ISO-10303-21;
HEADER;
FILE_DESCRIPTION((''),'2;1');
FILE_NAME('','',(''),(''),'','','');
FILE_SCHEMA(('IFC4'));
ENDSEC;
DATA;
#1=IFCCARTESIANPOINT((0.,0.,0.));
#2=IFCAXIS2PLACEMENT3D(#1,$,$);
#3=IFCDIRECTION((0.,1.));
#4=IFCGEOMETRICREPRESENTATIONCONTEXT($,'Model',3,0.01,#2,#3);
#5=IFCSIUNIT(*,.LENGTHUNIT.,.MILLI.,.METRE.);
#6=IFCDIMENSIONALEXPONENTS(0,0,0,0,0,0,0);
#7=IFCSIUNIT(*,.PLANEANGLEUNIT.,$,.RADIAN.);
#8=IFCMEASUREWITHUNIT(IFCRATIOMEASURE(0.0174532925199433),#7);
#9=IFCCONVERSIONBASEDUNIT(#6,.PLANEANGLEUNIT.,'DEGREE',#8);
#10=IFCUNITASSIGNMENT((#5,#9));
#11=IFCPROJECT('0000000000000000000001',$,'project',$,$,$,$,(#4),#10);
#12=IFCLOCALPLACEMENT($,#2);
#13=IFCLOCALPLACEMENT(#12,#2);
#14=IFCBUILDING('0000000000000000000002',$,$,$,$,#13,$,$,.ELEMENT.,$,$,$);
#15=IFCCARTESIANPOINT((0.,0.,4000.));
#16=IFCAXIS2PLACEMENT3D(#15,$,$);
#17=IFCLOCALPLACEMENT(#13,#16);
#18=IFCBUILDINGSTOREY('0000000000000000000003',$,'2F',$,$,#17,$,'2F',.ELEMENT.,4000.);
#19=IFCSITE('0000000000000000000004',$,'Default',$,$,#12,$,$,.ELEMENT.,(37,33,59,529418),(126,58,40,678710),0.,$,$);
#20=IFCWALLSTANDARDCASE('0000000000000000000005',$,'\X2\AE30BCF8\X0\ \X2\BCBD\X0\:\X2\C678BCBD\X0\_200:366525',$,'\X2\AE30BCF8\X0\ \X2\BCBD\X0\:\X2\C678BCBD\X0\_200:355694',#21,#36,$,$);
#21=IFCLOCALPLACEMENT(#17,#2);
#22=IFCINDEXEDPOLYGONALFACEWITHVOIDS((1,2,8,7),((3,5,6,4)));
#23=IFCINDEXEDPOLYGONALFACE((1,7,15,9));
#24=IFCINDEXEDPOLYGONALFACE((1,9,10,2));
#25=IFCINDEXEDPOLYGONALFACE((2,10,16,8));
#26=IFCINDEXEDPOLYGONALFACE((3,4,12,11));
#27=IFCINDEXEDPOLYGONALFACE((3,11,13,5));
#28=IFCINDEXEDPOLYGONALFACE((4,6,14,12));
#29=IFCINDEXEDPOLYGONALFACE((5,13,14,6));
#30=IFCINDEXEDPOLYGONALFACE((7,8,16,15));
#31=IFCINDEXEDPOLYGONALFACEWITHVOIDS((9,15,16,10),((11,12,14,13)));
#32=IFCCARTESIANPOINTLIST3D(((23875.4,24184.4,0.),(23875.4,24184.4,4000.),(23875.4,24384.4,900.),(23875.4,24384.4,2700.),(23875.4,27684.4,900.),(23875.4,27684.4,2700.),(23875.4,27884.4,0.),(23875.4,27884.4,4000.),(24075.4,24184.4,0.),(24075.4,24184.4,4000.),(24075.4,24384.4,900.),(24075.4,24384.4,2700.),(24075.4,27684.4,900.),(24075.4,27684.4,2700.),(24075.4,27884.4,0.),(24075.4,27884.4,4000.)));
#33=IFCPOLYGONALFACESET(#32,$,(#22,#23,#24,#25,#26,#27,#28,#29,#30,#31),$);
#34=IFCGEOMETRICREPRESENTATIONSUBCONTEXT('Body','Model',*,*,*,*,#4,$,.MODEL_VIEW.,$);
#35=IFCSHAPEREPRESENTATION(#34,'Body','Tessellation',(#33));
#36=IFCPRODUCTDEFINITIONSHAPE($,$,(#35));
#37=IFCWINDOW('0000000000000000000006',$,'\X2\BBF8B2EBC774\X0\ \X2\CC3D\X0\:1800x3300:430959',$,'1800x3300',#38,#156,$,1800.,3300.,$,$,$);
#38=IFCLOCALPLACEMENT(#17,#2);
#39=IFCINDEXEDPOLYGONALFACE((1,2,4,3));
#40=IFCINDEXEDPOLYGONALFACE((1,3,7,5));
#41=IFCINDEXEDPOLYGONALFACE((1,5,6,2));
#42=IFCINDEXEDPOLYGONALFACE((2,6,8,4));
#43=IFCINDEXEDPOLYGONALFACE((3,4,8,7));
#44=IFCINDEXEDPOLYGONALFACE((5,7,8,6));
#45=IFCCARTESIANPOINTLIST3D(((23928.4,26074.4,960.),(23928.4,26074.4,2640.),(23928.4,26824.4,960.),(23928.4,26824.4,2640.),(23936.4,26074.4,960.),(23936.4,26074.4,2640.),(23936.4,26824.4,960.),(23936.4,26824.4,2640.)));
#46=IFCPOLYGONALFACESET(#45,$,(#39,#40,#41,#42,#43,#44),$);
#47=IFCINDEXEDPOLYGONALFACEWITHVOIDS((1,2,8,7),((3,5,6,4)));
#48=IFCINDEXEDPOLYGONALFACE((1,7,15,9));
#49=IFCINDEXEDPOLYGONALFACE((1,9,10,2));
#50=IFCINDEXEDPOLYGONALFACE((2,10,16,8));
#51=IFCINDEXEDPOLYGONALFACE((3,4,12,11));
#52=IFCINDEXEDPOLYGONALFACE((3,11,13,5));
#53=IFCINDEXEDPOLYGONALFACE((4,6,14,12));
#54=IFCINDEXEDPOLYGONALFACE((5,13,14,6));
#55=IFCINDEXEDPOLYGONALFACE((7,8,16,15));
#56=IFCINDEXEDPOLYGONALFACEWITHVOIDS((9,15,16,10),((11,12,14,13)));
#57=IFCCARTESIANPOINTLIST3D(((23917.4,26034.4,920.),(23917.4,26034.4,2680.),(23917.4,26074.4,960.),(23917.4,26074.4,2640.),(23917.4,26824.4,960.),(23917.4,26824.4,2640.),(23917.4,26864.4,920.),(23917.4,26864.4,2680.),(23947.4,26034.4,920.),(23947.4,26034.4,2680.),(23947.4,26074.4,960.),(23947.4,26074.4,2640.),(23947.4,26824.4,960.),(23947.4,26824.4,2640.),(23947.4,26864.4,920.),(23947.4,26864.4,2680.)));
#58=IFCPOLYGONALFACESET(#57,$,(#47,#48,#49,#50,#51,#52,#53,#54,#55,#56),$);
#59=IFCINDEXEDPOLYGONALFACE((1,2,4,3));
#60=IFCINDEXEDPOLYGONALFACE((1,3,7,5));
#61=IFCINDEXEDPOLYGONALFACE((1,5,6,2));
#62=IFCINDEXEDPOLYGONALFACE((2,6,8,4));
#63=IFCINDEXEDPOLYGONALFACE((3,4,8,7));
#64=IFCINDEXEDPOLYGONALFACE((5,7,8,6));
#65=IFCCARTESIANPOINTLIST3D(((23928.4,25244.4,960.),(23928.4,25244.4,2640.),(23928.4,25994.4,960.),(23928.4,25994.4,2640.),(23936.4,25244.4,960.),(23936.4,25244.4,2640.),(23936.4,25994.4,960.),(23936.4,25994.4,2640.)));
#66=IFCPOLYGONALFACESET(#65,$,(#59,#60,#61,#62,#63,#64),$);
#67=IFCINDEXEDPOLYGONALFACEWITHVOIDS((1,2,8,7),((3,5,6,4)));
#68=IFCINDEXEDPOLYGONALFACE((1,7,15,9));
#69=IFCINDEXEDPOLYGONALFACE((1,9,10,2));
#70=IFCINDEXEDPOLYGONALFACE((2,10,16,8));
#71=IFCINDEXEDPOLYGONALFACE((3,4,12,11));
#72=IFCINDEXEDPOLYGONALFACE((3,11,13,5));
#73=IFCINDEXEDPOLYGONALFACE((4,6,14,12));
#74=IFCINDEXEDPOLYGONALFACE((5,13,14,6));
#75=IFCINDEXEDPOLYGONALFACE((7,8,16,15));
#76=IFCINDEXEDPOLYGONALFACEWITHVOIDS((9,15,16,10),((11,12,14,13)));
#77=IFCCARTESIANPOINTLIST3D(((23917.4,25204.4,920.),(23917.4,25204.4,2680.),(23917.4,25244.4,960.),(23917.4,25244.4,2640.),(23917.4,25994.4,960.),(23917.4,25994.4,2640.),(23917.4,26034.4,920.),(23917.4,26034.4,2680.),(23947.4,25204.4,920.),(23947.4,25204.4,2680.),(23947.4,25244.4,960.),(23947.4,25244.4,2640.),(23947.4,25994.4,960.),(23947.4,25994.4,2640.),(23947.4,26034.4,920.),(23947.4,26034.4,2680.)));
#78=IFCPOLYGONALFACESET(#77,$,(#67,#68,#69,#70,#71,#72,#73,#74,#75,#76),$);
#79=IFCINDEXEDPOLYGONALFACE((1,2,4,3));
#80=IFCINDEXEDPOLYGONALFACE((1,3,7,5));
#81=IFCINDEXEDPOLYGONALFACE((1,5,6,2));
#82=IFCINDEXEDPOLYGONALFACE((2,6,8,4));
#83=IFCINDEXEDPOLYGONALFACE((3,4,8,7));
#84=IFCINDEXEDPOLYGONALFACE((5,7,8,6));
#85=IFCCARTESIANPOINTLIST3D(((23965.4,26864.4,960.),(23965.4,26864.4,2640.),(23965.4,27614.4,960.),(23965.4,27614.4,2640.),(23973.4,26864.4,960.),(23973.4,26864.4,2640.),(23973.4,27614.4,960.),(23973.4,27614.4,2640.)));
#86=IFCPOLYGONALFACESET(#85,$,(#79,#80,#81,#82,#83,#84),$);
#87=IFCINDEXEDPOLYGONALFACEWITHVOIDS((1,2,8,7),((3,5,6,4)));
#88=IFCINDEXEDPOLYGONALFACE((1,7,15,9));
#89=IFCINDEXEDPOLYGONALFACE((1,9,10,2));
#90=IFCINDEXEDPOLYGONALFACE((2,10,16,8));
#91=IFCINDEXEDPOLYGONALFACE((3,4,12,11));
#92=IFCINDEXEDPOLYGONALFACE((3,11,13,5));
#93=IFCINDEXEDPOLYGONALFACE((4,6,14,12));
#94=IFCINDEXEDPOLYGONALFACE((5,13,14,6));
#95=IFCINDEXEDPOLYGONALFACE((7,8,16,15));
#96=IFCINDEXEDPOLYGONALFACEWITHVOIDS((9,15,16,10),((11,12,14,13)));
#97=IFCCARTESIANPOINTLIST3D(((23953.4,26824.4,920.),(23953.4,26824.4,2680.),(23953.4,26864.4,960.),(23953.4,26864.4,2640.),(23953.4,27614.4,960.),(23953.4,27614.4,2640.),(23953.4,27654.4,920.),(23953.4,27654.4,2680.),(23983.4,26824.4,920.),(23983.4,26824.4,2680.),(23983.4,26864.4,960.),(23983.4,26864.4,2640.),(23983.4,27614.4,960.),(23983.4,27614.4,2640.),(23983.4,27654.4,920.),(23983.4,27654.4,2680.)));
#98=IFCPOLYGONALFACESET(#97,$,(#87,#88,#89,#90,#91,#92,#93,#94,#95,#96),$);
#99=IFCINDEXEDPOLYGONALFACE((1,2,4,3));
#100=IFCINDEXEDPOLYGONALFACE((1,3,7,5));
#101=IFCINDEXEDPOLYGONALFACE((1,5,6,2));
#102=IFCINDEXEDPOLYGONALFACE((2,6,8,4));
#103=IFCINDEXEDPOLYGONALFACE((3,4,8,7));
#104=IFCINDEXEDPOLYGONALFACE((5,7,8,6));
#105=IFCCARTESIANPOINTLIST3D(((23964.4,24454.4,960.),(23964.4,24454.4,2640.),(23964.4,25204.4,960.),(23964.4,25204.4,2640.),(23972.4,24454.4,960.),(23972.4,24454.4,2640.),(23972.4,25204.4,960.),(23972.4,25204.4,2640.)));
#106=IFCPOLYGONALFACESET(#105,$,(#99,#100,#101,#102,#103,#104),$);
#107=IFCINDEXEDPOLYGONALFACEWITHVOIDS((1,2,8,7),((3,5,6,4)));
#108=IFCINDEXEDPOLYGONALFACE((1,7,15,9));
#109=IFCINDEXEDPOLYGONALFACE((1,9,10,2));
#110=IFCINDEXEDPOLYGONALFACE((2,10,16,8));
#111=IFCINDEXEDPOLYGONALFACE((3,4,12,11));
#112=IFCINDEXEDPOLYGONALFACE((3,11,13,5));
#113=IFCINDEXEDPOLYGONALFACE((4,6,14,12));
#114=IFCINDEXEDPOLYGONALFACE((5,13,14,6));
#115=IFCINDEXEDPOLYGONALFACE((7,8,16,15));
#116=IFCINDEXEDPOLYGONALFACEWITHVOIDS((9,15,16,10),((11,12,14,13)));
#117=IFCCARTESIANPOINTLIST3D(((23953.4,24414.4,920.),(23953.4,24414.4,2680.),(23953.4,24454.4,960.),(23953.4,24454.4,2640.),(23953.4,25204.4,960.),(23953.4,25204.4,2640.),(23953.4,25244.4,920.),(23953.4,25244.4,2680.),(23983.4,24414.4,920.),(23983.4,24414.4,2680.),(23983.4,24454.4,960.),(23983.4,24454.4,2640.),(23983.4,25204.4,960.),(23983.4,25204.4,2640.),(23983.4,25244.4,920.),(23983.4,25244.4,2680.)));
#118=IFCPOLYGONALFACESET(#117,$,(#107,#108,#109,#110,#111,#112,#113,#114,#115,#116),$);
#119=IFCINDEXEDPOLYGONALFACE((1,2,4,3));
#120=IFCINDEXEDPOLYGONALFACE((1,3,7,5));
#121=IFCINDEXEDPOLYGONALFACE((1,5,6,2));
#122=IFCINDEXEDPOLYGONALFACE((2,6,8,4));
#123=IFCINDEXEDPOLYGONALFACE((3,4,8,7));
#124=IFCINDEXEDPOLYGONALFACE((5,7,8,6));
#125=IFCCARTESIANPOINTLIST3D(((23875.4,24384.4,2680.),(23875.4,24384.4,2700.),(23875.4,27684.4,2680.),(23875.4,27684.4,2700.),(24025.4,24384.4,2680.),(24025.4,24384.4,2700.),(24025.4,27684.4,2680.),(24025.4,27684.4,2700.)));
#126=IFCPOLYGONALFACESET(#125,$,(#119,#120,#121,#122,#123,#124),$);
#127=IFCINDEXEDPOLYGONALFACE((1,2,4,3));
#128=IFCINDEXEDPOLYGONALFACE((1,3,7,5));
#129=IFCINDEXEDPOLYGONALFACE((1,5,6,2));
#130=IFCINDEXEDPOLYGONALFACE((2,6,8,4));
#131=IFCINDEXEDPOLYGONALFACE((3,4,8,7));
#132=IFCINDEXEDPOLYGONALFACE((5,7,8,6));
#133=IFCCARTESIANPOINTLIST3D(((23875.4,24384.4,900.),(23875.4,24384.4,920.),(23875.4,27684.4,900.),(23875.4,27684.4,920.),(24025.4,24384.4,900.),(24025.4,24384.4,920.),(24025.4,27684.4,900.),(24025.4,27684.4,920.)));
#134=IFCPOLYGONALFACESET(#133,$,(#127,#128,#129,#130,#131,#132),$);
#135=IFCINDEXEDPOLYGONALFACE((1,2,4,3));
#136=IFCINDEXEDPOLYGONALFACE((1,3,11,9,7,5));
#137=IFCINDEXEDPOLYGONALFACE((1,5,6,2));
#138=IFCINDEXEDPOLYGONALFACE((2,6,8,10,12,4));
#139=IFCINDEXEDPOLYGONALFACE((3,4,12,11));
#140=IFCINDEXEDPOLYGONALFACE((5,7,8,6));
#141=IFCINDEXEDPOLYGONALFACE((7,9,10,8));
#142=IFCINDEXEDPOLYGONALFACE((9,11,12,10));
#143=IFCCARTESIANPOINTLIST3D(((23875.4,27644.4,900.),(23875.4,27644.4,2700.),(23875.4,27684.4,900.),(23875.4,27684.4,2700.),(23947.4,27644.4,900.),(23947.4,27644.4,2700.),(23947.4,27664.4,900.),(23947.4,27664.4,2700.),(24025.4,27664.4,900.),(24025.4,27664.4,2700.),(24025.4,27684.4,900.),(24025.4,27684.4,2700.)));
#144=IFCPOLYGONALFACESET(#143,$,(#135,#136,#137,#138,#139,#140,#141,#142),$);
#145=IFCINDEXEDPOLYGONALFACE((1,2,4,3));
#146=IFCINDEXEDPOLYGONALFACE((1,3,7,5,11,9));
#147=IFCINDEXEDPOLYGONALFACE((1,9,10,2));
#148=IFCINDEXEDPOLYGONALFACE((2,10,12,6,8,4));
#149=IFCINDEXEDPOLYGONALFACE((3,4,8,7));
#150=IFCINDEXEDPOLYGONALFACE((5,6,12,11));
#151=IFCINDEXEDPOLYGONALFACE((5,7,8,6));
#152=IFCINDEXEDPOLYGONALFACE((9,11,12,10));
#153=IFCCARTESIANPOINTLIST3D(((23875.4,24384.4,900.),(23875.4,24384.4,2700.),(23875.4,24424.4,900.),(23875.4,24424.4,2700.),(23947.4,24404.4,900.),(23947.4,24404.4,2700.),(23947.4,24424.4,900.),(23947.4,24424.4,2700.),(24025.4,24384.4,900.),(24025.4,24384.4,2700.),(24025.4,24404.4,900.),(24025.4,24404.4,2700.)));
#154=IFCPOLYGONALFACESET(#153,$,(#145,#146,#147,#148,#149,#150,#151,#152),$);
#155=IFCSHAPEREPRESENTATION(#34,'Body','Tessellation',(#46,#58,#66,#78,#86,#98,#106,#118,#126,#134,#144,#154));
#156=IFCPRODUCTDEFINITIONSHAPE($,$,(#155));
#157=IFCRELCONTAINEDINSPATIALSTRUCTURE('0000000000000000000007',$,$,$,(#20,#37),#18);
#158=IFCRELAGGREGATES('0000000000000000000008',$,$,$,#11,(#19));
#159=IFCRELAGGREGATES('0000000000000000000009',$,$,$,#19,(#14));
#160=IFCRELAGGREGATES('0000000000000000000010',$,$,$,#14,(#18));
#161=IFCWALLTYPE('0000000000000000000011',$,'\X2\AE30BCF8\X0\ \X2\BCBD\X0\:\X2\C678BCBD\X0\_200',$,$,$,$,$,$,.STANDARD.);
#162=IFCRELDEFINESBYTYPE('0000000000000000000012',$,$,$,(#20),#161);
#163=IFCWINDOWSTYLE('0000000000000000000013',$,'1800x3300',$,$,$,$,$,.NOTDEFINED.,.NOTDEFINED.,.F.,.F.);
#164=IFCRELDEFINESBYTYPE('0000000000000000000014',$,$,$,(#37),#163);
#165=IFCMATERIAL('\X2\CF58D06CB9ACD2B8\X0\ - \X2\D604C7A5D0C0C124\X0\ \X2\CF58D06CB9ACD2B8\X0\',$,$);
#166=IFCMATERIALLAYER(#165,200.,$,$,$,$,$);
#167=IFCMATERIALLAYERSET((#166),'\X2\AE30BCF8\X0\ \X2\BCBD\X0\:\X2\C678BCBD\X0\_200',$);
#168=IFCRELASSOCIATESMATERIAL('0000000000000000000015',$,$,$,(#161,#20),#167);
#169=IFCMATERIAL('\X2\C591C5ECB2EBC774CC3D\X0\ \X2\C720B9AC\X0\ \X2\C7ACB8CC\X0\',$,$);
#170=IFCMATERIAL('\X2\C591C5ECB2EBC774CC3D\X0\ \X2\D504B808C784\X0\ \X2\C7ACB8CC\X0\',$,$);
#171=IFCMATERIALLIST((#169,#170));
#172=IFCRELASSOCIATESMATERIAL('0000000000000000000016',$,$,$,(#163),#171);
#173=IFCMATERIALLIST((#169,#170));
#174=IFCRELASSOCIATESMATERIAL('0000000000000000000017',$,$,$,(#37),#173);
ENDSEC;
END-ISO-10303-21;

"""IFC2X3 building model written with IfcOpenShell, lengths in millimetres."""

from ifc_helpers import new_model, entity, si_unit, converted_unit, direction, frame, frame_2d, origin, origin_2d_with_axis, place, context, subcontext, project, spatial, polyline, rectangle, outline, extrude, source, transform, mapped, material, material_list, layer, layer_set, layer_usage, type_object, type_shapes, element, fill, save


model = new_model("IFC2X3")

# Units and contexts
model_context = context("Model", 3, precision=0.01, world=origin(), true_north=direction((0.0, 1.0)))
body_context = subcontext(model_context, "Body", "Model", "MODEL_VIEW")
ifc_project = project(units=[si_unit("LENGTHUNIT", "METRE", prefix="MILLI"), converted_unit("PLANEANGLEUNIT", "DEGREE", entity("IfcRatioMeasure", 0.0174532925199433), si_unit("PLANEANGLEUNIT", "RADIAN"), dimensions=[0, 0, 0, 0, 0, 0, 0])], contexts=[model_context])

# Site, building, storey
site_placement = place(None, origin())
site = spatial("IfcSite", under=ifc_project, at=site_placement, Name="Default", CompositionType="ELEMENT", RefLatitude=(37, 33, 59, 529418), RefLongitude=(126, 58, 40, 678710), RefElevation=0.0)
building_placement = place(site_placement, origin())
building = spatial("IfcBuilding", under=site, at=building_placement, CompositionType="ELEMENT")
storey_placement = place(building_placement, frame((0.0, 0.0, 4000.0)))
storey = spatial("IfcBuildingStorey", under=building, at=storey_placement, Name="2F", LongName="2F", CompositionType="ELEMENT", Elevation=4000.0)

# Shared definitions
ifc_material_1 = material(Name="콘크리트 - 현장타설 콘크리트")

# Wall, opening, window
ifc_layer_1 = layer(ifc_material_1, 200.0)
ifc_layer_set_1 = layer_set([ifc_layer_1], Name="기본 벽:외벽_200")
wall_type_1 = type_object("IfcWallType", Name="기본 벽:외벽_200", PredefinedType="STANDARD", material=ifc_layer_set_1)
ifc_material_2 = material(Name="양여닫이창 유리 재료")
ifc_material_3 = material(Name="양여닫이창 프레임 재료")
ifc_material_list_1 = material_list([ifc_material_2, ifc_material_3])
window_style_1 = type_object("IfcWindowStyle", Name="1800x3300", ConstructionType="NOTDEFINED", OperationType="NOTDEFINED", ParameterTakesPrecedence=False, Sizeable=False, material=ifc_material_list_1)
shared_shape_1 = source(origin(), body_context, "Body", "SweptSolid", [
    extrude(rectangle(XDim=8.0, YDim=750.0, at=frame_2d((0.0, 0.0), x_axis=(1.0, 0.0))), frame((2065.0, 143.0, 60.0), z_axis=(0.0, 0.0, 1.0), x_axis=(0.0, 1.0, 0.0)), (0.0, 0.0, 1.0), 1680.0),
    extrude(outline(polyline([(-880.0, -415.0), (880.0, -415.0), (880.0, 415.0), (-880.0, 415.0), (-880.0, -415.0)]), holes=[polyline([(840.0, -375.0), (-840.0, -375.0), (-840.0, 375.0), (840.0, 375.0), (840.0, -375.0)])]), frame((2065.0, 128.0, 900.0), z_axis=(0.0, 1.0, 0.0), x_axis=(0.0, 0.0, -1.0)), (0.0, 0.0, 1.0), 30.0),
    extrude(rectangle(XDim=8.0, YDim=750.0, at=frame_2d((0.0, 0.0), x_axis=(1.0, 0.0))), frame((1235.0, 143.0, 60.0), z_axis=(0.0, 0.0, 1.0), x_axis=(0.0, 1.0, 0.0)), (0.0, 0.0, 1.0), 1680.0),
    extrude(outline(polyline([(-880.0, -415.0), (880.0, -415.0), (880.0, 415.0), (-880.0, 415.0), (-880.0, -415.0)]), holes=[polyline([(840.0, -375.0), (-840.0, -375.0), (-840.0, 375.0), (840.0, 375.0), (840.0, -375.0)])]), frame((1235.0, 128.0, 900.0), z_axis=(0.0, 1.0, 0.0), x_axis=(0.0, 0.0, -1.0)), (0.0, 0.0, 1.0), 30.0),
    extrude(rectangle(XDim=8.0, YDim=750.0, at=frame_2d((0.0, 0.0), x_axis=(1.0, 0.0))), frame((2855.0, 106.0, 60.0), z_axis=(0.0, 0.0, 1.0), x_axis=(0.0, 1.0, 0.0)), (0.0, 0.0, 1.0), 1680.0),
    extrude(outline(polyline([(-880.0, -415.0), (880.0, -415.0), (880.0, 415.0), (-880.0, 415.0), (-880.0, -415.0)]), holes=[polyline([(840.0, -375.0), (-840.0, -375.0), (-840.0, 375.0), (840.0, 375.0), (840.0, -375.0)])]), frame((2855.0, 92.0, 900.0), z_axis=(0.0, 1.0, 0.0), x_axis=(0.0, 0.0, -1.0)), (0.0, 0.0, 1.0), 30.0),
    extrude(rectangle(XDim=8.0, YDim=750.0, at=origin_2d_with_axis()), frame((445.0, 107.0, 60.0), z_axis=(0.0, 0.0, 1.0), x_axis=(0.0, 1.0, 0.0)), (0.0, 0.0, 1.0), 1680.0),
    extrude(outline(polyline([(-880.0, -415.0), (880.0, -415.0), (880.0, 415.0), (-880.0, 415.0), (-880.0, -415.0)]), holes=[polyline([(840.0, -375.0), (-840.0, -375.0), (-840.0, 375.0), (840.0, 375.0), (840.0, -375.0)])]), frame((445.0, 92.0, 900.0), z_axis=(0.0, 1.0, 0.0), x_axis=(0.0, 0.0, -1.0)), (0.0, 0.0, 1.0), 30.0),
    extrude(rectangle(XDim=3300.0, YDim=150.0, at=origin_2d_with_axis()), frame((1650.0, 125.0, 1780.0), z_axis=(0.0, 0.0, 1.0), x_axis=(-1.0, 0.0, 0.0)), (0.0, 0.0, 1.0), 20.0),
    extrude(rectangle(XDim=3300.0, YDim=150.0, at=origin_2d_with_axis()), frame((1650.0, 125.0, 0.0), z_axis=(0.0, 0.0, 1.0), x_axis=(-1.0, 0.0, 0.0)), (0.0, 0.0, 1.0), 20.0),
    extrude(outline(polyline([(-74.0, -20.0), (-2.0, -20.0), (-2.0, 0.0), (76.0, 0.0), (76.0, 20.0), (-74.0, 20.0), (-74.0, -20.0)])), frame((3280.0, 126.0, 0.0), z_axis=(0.0, 0.0, 1.0), x_axis=(0.0, -1.0, 0.0)), (0.0, 0.0, 1.0), 1800.0),
    extrude(outline(polyline([(-20.0, -74.0), (20.0, -74.0), (20.0, 76.0), (0.0, 76.0), (0.0, -2.0), (-20.0, -2.0), (-20.0, -74.0)])), frame((20.0, 126.0, 0.0), z_axis=(0.0, 0.0, 1.0), x_axis=(-1.0, 0.0, 0.0)), (0.0, 0.0, 1.0), 1800.0),
])
type_shapes(window_style_1, [shared_shape_1])
ifc_layer_usage_1 = layer_usage(ifc_layer_set_1, "AXIS2", "NEGATIVE", 100.0)
wall_1_placement = place(storey_placement, frame((23975.4, 24184.4, 0.0), z_axis=(0.0, 0.0, 1.0), x_axis=(0.0, 1.0, 0.0)))
wall_1 = element("IfcWallStandardCase", 1, at=wall_1_placement, inside=storey, type_object=wall_type_1, material=ifc_layer_usage_1, Name="기본 벽:외벽_200:366525", ObjectType="기본 벽:외벽_200:355694", context=body_context, shape_type="SweptSolid", body=[
    extrude(rectangle(XDim=3700.0, YDim=200.0, at=frame_2d((1850.0, 0.0), x_axis=(-1.0, 0.0))), origin(), (0.0, 0.0, 1.0), 4000.0),
])
opening_1_placement = place(wall_1_placement, frame((200.0, -100.0, 900.0)))
opening_1 = element("IfcOpeningElement", 2, at=opening_1_placement, cuts=wall_1, ObjectType="Opening", context=body_context, shape_type="SweptSolid", body=[
    extrude(rectangle(XDim=1800.0, YDim=3300.0, at=frame_2d((900.0, 1650.0), x_axis=(1.0, 0.0))), frame((0.0, 0.0, 0.0), z_axis=(0.0, 1.0, 0.0), x_axis=(0.0, 0.0, 1.0)), (0.0, 0.0, 1.0), 200.0),
])
ifc_material_list_2 = material_list([ifc_material_2, ifc_material_3])
window_1_placement = place(opening_1_placement, origin())
window_1 = element("IfcWindow", 3, at=window_1_placement, inside=storey, type_object=window_style_1, material=ifc_material_list_2, Name="미닫이 창:1800x3300:430959", ObjectType="1800x3300", OverallHeight=1800.0, OverallWidth=3300.0, context=body_context, shape_type="MappedRepresentation", body=[
    mapped(shared_shape_1, transform((0.0, 0.0, 0.0), scale=1.0)),
])
fill(opening_1, window_1)

save(model, "model.ifc")
